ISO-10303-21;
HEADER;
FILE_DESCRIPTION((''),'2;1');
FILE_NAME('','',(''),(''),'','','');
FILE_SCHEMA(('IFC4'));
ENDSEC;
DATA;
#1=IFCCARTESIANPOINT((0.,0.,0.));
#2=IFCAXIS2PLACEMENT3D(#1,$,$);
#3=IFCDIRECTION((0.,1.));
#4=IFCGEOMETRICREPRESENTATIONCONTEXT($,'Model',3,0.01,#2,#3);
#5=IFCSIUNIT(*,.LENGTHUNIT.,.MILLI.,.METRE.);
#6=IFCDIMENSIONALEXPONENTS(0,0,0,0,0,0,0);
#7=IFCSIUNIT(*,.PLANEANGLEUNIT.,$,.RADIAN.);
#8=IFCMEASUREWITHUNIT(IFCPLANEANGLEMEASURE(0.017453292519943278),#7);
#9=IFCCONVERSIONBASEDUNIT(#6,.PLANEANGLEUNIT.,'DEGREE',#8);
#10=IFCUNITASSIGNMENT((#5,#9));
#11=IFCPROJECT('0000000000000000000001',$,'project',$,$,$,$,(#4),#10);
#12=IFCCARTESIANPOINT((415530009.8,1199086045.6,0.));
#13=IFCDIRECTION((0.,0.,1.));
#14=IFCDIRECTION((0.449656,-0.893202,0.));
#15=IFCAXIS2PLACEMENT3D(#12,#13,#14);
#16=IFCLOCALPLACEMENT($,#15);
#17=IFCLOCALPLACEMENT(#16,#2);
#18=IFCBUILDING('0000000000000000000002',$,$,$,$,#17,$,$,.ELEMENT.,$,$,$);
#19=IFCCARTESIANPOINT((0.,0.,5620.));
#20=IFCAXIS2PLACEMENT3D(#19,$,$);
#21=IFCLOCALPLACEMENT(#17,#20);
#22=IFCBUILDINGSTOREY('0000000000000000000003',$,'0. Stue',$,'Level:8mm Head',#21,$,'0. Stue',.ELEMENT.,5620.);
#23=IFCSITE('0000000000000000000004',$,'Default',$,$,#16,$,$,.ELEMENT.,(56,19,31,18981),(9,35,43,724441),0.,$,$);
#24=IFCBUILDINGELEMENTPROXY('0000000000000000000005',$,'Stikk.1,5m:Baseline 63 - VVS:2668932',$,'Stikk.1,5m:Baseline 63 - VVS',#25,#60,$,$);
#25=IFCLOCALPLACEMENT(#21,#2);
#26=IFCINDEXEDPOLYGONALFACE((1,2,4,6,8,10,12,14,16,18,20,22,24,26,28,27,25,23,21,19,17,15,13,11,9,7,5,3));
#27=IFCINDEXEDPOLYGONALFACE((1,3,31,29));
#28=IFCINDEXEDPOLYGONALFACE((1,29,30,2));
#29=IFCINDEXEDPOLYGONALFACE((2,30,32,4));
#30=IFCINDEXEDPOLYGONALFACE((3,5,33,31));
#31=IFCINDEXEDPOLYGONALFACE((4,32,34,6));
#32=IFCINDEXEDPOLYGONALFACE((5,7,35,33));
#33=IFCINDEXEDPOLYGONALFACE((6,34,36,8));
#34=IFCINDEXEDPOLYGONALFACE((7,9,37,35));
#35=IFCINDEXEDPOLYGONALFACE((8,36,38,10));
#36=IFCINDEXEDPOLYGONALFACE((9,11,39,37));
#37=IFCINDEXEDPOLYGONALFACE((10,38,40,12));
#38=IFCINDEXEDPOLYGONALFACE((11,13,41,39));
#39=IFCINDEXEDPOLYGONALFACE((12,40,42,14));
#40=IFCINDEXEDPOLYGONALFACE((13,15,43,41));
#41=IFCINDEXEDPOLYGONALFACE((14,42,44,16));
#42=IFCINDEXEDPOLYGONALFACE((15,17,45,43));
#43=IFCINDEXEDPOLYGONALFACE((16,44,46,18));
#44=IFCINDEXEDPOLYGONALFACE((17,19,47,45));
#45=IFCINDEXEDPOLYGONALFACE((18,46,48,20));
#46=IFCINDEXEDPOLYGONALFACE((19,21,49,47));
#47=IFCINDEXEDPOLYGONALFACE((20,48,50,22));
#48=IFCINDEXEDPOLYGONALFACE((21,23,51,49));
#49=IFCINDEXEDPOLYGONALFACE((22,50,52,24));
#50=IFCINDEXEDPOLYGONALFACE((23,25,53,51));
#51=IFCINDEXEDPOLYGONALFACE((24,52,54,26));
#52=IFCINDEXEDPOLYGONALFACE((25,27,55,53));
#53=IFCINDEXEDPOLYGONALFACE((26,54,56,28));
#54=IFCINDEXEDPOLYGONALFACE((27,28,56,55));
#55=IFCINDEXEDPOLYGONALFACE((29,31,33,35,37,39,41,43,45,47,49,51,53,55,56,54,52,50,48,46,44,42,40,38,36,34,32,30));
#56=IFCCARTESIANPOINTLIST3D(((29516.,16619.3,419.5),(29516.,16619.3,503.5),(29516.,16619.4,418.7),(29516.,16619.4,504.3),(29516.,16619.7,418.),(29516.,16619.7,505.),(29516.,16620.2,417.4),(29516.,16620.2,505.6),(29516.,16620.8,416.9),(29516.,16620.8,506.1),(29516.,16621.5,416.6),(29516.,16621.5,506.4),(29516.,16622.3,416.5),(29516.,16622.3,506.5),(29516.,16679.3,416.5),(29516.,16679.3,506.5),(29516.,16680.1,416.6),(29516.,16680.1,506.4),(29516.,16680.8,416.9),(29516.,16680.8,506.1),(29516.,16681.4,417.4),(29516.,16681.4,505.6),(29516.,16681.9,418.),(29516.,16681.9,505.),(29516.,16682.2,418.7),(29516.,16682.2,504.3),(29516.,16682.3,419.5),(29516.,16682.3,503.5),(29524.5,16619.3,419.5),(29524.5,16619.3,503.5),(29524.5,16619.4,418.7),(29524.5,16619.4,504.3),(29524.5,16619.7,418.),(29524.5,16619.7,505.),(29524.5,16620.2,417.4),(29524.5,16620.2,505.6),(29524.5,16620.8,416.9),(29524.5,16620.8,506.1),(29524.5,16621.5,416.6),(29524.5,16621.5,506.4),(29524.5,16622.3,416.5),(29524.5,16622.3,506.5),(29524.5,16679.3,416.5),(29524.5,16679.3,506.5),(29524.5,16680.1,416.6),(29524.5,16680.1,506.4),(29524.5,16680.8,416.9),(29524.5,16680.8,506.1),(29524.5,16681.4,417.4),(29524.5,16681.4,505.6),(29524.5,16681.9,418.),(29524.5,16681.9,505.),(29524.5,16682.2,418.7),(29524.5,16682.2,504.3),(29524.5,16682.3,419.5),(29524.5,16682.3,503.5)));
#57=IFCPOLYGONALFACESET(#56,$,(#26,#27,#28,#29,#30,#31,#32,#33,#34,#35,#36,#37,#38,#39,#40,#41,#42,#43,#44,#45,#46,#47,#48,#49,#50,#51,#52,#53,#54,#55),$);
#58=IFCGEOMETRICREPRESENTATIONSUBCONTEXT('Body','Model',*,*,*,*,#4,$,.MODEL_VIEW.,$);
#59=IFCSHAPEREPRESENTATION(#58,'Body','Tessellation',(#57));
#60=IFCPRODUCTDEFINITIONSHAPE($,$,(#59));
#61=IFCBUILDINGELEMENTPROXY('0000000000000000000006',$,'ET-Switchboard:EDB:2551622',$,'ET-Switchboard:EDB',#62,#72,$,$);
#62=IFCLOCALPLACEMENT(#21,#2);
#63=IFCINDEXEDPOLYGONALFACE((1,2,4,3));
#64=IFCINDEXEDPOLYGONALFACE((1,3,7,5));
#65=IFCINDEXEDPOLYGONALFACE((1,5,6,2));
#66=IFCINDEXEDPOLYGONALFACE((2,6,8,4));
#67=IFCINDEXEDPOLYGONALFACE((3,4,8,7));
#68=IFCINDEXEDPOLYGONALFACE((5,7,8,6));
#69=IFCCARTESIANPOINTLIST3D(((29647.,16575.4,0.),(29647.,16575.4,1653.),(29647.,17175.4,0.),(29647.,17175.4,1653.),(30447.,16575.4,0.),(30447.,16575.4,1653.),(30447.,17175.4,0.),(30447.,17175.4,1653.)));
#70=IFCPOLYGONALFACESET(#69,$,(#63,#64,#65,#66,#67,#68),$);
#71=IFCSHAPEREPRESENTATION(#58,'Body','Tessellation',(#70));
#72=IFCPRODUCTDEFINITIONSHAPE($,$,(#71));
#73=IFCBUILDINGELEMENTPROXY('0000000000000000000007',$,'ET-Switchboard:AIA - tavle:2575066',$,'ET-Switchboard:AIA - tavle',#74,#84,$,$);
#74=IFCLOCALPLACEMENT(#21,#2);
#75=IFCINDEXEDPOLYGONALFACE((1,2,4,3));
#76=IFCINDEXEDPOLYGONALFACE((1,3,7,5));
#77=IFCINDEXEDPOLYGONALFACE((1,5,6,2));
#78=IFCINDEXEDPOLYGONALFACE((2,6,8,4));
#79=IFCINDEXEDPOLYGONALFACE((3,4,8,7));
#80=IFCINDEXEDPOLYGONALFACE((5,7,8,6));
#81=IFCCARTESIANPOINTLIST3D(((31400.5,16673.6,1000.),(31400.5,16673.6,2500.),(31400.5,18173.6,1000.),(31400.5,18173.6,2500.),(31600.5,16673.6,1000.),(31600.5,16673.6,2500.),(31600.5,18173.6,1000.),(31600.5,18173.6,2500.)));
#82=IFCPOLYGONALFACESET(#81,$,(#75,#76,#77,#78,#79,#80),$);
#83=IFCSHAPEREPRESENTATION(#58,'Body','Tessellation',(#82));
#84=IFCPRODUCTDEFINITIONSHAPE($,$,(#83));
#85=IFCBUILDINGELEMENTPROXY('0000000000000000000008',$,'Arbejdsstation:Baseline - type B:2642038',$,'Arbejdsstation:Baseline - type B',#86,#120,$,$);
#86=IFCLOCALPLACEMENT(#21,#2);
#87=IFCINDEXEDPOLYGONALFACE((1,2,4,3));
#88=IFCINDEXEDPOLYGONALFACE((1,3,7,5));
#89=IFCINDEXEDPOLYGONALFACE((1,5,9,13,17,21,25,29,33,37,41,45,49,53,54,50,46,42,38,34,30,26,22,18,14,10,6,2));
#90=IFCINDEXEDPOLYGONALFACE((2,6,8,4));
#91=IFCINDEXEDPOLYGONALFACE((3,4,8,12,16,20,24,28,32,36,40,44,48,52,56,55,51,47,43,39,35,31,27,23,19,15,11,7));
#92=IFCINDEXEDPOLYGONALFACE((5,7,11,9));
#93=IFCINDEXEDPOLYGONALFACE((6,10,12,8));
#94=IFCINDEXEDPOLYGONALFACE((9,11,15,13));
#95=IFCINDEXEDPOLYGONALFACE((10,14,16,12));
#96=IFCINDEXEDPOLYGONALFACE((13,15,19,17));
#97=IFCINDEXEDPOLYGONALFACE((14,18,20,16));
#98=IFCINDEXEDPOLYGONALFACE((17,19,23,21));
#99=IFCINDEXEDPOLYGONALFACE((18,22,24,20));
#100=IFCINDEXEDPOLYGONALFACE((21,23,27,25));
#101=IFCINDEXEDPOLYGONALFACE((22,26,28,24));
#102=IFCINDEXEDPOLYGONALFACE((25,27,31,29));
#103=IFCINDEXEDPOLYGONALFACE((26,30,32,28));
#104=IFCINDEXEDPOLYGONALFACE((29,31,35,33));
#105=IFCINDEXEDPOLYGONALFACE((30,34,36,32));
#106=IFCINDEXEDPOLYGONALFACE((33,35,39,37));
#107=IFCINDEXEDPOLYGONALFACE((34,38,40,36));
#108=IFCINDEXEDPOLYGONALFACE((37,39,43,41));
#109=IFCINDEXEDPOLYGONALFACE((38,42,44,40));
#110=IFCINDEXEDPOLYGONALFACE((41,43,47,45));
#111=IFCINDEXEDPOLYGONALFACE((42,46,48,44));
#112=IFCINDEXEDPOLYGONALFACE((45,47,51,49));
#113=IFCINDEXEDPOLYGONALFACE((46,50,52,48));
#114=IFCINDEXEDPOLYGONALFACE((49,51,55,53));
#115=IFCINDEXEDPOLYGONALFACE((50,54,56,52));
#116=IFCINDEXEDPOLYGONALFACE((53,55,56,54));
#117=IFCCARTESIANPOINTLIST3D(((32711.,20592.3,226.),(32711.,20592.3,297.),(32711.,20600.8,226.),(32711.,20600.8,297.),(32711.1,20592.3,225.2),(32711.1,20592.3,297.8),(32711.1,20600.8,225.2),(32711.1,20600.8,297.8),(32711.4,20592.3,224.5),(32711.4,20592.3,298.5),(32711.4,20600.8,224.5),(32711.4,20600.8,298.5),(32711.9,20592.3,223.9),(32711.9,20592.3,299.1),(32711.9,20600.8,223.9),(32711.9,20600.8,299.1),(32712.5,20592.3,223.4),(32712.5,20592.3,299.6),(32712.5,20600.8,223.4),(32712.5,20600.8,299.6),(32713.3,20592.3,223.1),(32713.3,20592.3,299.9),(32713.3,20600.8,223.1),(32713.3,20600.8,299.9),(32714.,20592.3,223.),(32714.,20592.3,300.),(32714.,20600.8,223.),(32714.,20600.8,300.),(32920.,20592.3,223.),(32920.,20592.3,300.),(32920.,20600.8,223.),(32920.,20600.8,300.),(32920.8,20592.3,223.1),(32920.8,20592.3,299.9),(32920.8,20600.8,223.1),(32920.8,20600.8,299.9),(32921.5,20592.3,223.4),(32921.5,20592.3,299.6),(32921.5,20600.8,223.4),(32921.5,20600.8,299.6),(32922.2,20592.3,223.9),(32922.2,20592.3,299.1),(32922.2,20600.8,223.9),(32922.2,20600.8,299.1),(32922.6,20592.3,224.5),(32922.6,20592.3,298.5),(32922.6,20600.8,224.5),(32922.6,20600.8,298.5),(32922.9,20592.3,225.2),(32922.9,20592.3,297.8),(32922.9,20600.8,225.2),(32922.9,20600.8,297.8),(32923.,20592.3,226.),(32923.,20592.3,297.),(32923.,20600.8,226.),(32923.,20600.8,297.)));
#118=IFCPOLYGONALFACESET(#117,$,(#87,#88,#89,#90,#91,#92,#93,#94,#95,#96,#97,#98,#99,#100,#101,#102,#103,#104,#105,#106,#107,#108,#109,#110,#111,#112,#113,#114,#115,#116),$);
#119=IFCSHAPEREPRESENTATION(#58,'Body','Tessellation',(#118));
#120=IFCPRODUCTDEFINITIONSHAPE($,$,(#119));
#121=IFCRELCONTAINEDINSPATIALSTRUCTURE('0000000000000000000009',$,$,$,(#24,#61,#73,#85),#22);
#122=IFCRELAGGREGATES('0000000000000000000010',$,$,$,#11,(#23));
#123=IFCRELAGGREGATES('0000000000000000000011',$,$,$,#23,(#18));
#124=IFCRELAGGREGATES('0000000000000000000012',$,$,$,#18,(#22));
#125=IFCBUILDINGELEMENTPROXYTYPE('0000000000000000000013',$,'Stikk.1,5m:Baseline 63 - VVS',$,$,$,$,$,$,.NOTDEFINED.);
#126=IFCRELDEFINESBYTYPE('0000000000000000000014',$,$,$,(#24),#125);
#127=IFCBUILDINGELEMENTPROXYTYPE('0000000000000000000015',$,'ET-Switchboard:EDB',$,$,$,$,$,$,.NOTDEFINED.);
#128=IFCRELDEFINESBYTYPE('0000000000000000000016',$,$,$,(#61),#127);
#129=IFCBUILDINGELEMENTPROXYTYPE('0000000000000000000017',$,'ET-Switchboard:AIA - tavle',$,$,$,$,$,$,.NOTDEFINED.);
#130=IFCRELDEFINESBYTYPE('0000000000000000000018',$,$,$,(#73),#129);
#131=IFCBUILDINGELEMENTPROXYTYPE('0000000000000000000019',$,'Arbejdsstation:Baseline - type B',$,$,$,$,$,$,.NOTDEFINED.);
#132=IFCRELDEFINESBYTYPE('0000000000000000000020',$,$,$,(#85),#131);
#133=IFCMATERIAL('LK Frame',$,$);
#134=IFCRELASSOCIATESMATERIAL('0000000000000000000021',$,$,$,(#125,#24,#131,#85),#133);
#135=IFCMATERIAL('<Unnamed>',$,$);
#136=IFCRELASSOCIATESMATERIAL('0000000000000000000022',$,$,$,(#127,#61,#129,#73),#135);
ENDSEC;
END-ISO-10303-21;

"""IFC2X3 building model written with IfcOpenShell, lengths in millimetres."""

from ifc_helpers import new_model, entity, si_unit, converted_unit, direction, frame, frame_2d, origin, origin_2d_with_axis, place, context, subcontext, project, spatial, polyline, circle_curve, parameter, trimmed, segment, composite_curve, rectangle, outline, extrude, source, transform, mapped, material, type_object, type_shapes, element, save


model = new_model("IFC2X3")

# Units and contexts
model_context = context("Model", 3, precision=0.01, world=origin(), true_north=direction((0.0, 1.0)))
body_context = subcontext(model_context, "Body", "Model", "MODEL_VIEW")
ifc_project = project(units=[si_unit("LENGTHUNIT", "METRE", prefix="MILLI"), converted_unit("PLANEANGLEUNIT", "DEGREE", entity("IfcPlaneAngleMeasure", 0.017453292519943278), si_unit("PLANEANGLEUNIT", "RADIAN"), dimensions=[0, 0, 0, 0, 0, 0, 0])], contexts=[model_context])

# Site, building, storey
site_placement = place(None, frame((415530009.8, 1199086045.6, 0.0), z_axis=(0.0, 0.0, 1.0), x_axis=(0.449656, -0.893202, 0.0)))
site = spatial("IfcSite", under=ifc_project, at=site_placement, Name="Default", CompositionType="ELEMENT", RefLatitude=(56, 19, 31, 18981), RefLongitude=(9, 35, 43, 724441), RefElevation=0.0)
building_placement = place(site_placement, origin())
building = spatial("IfcBuilding", under=site, at=building_placement, CompositionType="ELEMENT")
storey_placement = place(building_placement, frame((0.0, 0.0, 5620.0)))
storey = spatial("IfcBuildingStorey", under=building, at=storey_placement, Name="0. Stue", ObjectType="Level:8mm Head", LongName="0. Stue", CompositionType="ELEMENT", Elevation=5620.0)

# Building element proxies
ifc_material_1 = material(Name="LK Frame")
building_element_proxy_type_1 = type_object("IfcBuildingElementProxyType", Name="Stikk.1,5m:Baseline 63 - VVS", PredefinedType="NOTDEFINED", material=ifc_material_1)
shared_shape_1 = source(origin(), body_context, "Body", "SweptSolid", [
    extrude(outline(composite_curve([segment(polyline([(-42.0, -31.5), (42.0, -31.5)]), True, "CONTINUOUS"), segment(trimmed(circle_curve(frame_2d((42.0, -28.5), x_axis=(-1.0, 0.0)), 3.0), [parameter(90.0)], [parameter(180.0)], True, "PARAMETER"), True, "CONTINUOUS"), segment(polyline([(45.0, -28.5), (45.0, 28.5)]), True, "CONTINUOUS"), segment(trimmed(circle_curve(frame_2d((42.0, 28.5), x_axis=(-1.0, 0.0)), 3.0), [parameter(180.0)], [parameter(270.0)], True, "PARAMETER"), True, "CONTINUOUS"), segment(polyline([(42.0, 31.5), (-42.0, 31.5)]), True, "CONTINUOUS"), segment(trimmed(circle_curve(frame_2d((-42.0, 28.5), x_axis=(1.0, 0.0)), 3.0), [parameter(90.0)], [parameter(180.0)], True, "PARAMETER"), True, "CONTINUOUS"), segment(polyline([(-45.0, 28.5), (-45.0, -28.5)]), True, "CONTINUOUS"), segment(trimmed(circle_curve(frame_2d((-42.0, -28.5), x_axis=(1.0, 0.0)), 3.0), [parameter(180.0)], [parameter(270.0)], True, "PARAMETER"), True, "CONTINUOUS")], self_intersect=False)), frame((0.0, -38.5, 0.0), z_axis=(0.0, 0.0, 1.0), x_axis=(0.0, 1.0, 0.0)), (0.0, 0.0, 1.0), 8.5),
])
type_shapes(building_element_proxy_type_1, [shared_shape_1])
proxy_1_placement = place(storey_placement, frame((29524.5, 16650.8, 500.0), z_axis=(-1.0, 0.0, 0.0), x_axis=(0.0, -1.0, 0.0)))
element("IfcBuildingElementProxy", 1, at=proxy_1_placement, inside=storey, type_object=building_element_proxy_type_1, material=ifc_material_1, Name="Stikk.1,5m:Baseline 63 - VVS:2668932", ObjectType="Stikk.1,5m:Baseline 63 - VVS", context=body_context, shape_type="MappedRepresentation", body=[
    mapped(shared_shape_1, transform((0.0, 0.0, 0.0), scale=1.0)),
])
ifc_material_2 = material(Name="<Unnamed>")
building_element_proxy_type_2 = type_object("IfcBuildingElementProxyType", Name="ET-Switchboard:EDB", PredefinedType="NOTDEFINED", material=ifc_material_2)
shared_shape_2 = source(origin(), body_context, "Body", "SweptSolid", [
    extrude(rectangle(XDim=800.0, YDim=600.0, at=origin_2d_with_axis()), frame((0.0, 400.0, 0.0), z_axis=(0.0, 0.0, 1.0), x_axis=(0.0, 1.0, 0.0)), (0.0, 0.0, 1.0), 1653.0),
])
type_shapes(building_element_proxy_type_2, [shared_shape_2])
proxy_2_placement = place(storey_placement, frame((29647.0, 16875.4, 0.0), z_axis=(0.0, 0.0, 1.0), x_axis=(0.0, -1.0, 0.0)))
element("IfcBuildingElementProxy", 2, at=proxy_2_placement, inside=storey, type_object=building_element_proxy_type_2, material=ifc_material_2, Name="ET-Switchboard:EDB:2551622", ObjectType="ET-Switchboard:EDB", context=body_context, shape_type="MappedRepresentation", body=[
    mapped(shared_shape_2, transform((0.0, 0.0, 0.0), scale=1.0)),
])
building_element_proxy_type_3 = type_object("IfcBuildingElementProxyType", Name="ET-Switchboard:AIA - tavle", PredefinedType="NOTDEFINED", material=ifc_material_2)
shared_shape_3 = source(origin(), body_context, "Body", "SweptSolid", [
    extrude(rectangle(XDim=200.0, YDim=1500.0, at=origin_2d_with_axis()), frame((0.0, 100.0, 0.0), z_axis=(0.0, 0.0, 1.0), x_axis=(0.0, 1.0, 0.0)), (0.0, 0.0, 1.0), 1500.0),
])
type_shapes(building_element_proxy_type_3, [shared_shape_3])
proxy_3_placement = place(storey_placement, frame((31600.5, 17423.6, 1000.0), z_axis=(0.0, 0.0, 1.0), x_axis=(0.0, 1.0, 0.0)))
element("IfcBuildingElementProxy", 3, at=proxy_3_placement, inside=storey, type_object=building_element_proxy_type_3, material=ifc_material_2, Name="ET-Switchboard:AIA - tavle:2575066", ObjectType="ET-Switchboard:AIA - tavle", context=body_context, shape_type="MappedRepresentation", body=[
    mapped(shared_shape_3, transform((0.0, 0.0, 0.0), scale=1.0)),
])
building_element_proxy_type_4 = type_object("IfcBuildingElementProxyType", Name="Arbejdsstation:Baseline - type B", PredefinedType="NOTDEFINED", material=ifc_material_1)
shared_shape_4 = source(origin(), body_context, "Body", "SweptSolid", [
    extrude(outline(composite_curve([segment(polyline([(-35.5, -106.0), (35.5, -106.0)]), True, "CONTINUOUS"), segment(trimmed(circle_curve(frame_2d((35.5, -103.0), x_axis=(-1.0, 0.0)), 3.0), [parameter(90.0)], [parameter(180.0)], True, "PARAMETER"), True, "CONTINUOUS"), segment(polyline([(38.5, -103.0), (38.5, 103.0)]), True, "CONTINUOUS"), segment(trimmed(circle_curve(frame_2d((35.5, 103.0), x_axis=(-1.0, 0.0)), 3.0), [parameter(180.0)], [parameter(270.0)], True, "PARAMETER"), True, "CONTINUOUS"), segment(polyline([(35.5, 106.0), (-35.5, 106.0)]), True, "CONTINUOUS"), segment(trimmed(circle_curve(frame_2d((-35.5, 103.0), x_axis=(1.0, 0.0)), 3.0), [parameter(90.0)], [parameter(180.0)], True, "PARAMETER"), True, "CONTINUOUS"), segment(polyline([(-38.5, 103.0), (-38.5, -103.0)]), True, "CONTINUOUS"), segment(trimmed(circle_curve(frame_2d((-35.5, -103.0), x_axis=(1.0, 0.0)), 3.0), [parameter(180.0)], [parameter(270.0)], True, "PARAMETER"), True, "CONTINUOUS")], self_intersect=False)), frame((-3.5, -38.5, 0.0), z_axis=(0.0, 0.0, 1.0), x_axis=(0.0, 1.0, 0.0)), (0.0, 0.0, 1.0), 8.5),
])
type_shapes(building_element_proxy_type_4, [shared_shape_4])
proxy_4_placement = place(storey_placement, frame((32820.5, 20600.8, 300.0), z_axis=(0.0, -1.0, 0.0), x_axis=(1.0, 0.0, 0.0)))
element("IfcBuildingElementProxy", 4, at=proxy_4_placement, inside=storey, type_object=building_element_proxy_type_4, material=ifc_material_1, Name="Arbejdsstation:Baseline - type B:2642038", ObjectType="Arbejdsstation:Baseline - type B", context=body_context, shape_type="MappedRepresentation", body=[
    mapped(shared_shape_4, transform((0.0, 0.0, 0.0), scale=1.0)),
])

save(model, "model.ifc")
